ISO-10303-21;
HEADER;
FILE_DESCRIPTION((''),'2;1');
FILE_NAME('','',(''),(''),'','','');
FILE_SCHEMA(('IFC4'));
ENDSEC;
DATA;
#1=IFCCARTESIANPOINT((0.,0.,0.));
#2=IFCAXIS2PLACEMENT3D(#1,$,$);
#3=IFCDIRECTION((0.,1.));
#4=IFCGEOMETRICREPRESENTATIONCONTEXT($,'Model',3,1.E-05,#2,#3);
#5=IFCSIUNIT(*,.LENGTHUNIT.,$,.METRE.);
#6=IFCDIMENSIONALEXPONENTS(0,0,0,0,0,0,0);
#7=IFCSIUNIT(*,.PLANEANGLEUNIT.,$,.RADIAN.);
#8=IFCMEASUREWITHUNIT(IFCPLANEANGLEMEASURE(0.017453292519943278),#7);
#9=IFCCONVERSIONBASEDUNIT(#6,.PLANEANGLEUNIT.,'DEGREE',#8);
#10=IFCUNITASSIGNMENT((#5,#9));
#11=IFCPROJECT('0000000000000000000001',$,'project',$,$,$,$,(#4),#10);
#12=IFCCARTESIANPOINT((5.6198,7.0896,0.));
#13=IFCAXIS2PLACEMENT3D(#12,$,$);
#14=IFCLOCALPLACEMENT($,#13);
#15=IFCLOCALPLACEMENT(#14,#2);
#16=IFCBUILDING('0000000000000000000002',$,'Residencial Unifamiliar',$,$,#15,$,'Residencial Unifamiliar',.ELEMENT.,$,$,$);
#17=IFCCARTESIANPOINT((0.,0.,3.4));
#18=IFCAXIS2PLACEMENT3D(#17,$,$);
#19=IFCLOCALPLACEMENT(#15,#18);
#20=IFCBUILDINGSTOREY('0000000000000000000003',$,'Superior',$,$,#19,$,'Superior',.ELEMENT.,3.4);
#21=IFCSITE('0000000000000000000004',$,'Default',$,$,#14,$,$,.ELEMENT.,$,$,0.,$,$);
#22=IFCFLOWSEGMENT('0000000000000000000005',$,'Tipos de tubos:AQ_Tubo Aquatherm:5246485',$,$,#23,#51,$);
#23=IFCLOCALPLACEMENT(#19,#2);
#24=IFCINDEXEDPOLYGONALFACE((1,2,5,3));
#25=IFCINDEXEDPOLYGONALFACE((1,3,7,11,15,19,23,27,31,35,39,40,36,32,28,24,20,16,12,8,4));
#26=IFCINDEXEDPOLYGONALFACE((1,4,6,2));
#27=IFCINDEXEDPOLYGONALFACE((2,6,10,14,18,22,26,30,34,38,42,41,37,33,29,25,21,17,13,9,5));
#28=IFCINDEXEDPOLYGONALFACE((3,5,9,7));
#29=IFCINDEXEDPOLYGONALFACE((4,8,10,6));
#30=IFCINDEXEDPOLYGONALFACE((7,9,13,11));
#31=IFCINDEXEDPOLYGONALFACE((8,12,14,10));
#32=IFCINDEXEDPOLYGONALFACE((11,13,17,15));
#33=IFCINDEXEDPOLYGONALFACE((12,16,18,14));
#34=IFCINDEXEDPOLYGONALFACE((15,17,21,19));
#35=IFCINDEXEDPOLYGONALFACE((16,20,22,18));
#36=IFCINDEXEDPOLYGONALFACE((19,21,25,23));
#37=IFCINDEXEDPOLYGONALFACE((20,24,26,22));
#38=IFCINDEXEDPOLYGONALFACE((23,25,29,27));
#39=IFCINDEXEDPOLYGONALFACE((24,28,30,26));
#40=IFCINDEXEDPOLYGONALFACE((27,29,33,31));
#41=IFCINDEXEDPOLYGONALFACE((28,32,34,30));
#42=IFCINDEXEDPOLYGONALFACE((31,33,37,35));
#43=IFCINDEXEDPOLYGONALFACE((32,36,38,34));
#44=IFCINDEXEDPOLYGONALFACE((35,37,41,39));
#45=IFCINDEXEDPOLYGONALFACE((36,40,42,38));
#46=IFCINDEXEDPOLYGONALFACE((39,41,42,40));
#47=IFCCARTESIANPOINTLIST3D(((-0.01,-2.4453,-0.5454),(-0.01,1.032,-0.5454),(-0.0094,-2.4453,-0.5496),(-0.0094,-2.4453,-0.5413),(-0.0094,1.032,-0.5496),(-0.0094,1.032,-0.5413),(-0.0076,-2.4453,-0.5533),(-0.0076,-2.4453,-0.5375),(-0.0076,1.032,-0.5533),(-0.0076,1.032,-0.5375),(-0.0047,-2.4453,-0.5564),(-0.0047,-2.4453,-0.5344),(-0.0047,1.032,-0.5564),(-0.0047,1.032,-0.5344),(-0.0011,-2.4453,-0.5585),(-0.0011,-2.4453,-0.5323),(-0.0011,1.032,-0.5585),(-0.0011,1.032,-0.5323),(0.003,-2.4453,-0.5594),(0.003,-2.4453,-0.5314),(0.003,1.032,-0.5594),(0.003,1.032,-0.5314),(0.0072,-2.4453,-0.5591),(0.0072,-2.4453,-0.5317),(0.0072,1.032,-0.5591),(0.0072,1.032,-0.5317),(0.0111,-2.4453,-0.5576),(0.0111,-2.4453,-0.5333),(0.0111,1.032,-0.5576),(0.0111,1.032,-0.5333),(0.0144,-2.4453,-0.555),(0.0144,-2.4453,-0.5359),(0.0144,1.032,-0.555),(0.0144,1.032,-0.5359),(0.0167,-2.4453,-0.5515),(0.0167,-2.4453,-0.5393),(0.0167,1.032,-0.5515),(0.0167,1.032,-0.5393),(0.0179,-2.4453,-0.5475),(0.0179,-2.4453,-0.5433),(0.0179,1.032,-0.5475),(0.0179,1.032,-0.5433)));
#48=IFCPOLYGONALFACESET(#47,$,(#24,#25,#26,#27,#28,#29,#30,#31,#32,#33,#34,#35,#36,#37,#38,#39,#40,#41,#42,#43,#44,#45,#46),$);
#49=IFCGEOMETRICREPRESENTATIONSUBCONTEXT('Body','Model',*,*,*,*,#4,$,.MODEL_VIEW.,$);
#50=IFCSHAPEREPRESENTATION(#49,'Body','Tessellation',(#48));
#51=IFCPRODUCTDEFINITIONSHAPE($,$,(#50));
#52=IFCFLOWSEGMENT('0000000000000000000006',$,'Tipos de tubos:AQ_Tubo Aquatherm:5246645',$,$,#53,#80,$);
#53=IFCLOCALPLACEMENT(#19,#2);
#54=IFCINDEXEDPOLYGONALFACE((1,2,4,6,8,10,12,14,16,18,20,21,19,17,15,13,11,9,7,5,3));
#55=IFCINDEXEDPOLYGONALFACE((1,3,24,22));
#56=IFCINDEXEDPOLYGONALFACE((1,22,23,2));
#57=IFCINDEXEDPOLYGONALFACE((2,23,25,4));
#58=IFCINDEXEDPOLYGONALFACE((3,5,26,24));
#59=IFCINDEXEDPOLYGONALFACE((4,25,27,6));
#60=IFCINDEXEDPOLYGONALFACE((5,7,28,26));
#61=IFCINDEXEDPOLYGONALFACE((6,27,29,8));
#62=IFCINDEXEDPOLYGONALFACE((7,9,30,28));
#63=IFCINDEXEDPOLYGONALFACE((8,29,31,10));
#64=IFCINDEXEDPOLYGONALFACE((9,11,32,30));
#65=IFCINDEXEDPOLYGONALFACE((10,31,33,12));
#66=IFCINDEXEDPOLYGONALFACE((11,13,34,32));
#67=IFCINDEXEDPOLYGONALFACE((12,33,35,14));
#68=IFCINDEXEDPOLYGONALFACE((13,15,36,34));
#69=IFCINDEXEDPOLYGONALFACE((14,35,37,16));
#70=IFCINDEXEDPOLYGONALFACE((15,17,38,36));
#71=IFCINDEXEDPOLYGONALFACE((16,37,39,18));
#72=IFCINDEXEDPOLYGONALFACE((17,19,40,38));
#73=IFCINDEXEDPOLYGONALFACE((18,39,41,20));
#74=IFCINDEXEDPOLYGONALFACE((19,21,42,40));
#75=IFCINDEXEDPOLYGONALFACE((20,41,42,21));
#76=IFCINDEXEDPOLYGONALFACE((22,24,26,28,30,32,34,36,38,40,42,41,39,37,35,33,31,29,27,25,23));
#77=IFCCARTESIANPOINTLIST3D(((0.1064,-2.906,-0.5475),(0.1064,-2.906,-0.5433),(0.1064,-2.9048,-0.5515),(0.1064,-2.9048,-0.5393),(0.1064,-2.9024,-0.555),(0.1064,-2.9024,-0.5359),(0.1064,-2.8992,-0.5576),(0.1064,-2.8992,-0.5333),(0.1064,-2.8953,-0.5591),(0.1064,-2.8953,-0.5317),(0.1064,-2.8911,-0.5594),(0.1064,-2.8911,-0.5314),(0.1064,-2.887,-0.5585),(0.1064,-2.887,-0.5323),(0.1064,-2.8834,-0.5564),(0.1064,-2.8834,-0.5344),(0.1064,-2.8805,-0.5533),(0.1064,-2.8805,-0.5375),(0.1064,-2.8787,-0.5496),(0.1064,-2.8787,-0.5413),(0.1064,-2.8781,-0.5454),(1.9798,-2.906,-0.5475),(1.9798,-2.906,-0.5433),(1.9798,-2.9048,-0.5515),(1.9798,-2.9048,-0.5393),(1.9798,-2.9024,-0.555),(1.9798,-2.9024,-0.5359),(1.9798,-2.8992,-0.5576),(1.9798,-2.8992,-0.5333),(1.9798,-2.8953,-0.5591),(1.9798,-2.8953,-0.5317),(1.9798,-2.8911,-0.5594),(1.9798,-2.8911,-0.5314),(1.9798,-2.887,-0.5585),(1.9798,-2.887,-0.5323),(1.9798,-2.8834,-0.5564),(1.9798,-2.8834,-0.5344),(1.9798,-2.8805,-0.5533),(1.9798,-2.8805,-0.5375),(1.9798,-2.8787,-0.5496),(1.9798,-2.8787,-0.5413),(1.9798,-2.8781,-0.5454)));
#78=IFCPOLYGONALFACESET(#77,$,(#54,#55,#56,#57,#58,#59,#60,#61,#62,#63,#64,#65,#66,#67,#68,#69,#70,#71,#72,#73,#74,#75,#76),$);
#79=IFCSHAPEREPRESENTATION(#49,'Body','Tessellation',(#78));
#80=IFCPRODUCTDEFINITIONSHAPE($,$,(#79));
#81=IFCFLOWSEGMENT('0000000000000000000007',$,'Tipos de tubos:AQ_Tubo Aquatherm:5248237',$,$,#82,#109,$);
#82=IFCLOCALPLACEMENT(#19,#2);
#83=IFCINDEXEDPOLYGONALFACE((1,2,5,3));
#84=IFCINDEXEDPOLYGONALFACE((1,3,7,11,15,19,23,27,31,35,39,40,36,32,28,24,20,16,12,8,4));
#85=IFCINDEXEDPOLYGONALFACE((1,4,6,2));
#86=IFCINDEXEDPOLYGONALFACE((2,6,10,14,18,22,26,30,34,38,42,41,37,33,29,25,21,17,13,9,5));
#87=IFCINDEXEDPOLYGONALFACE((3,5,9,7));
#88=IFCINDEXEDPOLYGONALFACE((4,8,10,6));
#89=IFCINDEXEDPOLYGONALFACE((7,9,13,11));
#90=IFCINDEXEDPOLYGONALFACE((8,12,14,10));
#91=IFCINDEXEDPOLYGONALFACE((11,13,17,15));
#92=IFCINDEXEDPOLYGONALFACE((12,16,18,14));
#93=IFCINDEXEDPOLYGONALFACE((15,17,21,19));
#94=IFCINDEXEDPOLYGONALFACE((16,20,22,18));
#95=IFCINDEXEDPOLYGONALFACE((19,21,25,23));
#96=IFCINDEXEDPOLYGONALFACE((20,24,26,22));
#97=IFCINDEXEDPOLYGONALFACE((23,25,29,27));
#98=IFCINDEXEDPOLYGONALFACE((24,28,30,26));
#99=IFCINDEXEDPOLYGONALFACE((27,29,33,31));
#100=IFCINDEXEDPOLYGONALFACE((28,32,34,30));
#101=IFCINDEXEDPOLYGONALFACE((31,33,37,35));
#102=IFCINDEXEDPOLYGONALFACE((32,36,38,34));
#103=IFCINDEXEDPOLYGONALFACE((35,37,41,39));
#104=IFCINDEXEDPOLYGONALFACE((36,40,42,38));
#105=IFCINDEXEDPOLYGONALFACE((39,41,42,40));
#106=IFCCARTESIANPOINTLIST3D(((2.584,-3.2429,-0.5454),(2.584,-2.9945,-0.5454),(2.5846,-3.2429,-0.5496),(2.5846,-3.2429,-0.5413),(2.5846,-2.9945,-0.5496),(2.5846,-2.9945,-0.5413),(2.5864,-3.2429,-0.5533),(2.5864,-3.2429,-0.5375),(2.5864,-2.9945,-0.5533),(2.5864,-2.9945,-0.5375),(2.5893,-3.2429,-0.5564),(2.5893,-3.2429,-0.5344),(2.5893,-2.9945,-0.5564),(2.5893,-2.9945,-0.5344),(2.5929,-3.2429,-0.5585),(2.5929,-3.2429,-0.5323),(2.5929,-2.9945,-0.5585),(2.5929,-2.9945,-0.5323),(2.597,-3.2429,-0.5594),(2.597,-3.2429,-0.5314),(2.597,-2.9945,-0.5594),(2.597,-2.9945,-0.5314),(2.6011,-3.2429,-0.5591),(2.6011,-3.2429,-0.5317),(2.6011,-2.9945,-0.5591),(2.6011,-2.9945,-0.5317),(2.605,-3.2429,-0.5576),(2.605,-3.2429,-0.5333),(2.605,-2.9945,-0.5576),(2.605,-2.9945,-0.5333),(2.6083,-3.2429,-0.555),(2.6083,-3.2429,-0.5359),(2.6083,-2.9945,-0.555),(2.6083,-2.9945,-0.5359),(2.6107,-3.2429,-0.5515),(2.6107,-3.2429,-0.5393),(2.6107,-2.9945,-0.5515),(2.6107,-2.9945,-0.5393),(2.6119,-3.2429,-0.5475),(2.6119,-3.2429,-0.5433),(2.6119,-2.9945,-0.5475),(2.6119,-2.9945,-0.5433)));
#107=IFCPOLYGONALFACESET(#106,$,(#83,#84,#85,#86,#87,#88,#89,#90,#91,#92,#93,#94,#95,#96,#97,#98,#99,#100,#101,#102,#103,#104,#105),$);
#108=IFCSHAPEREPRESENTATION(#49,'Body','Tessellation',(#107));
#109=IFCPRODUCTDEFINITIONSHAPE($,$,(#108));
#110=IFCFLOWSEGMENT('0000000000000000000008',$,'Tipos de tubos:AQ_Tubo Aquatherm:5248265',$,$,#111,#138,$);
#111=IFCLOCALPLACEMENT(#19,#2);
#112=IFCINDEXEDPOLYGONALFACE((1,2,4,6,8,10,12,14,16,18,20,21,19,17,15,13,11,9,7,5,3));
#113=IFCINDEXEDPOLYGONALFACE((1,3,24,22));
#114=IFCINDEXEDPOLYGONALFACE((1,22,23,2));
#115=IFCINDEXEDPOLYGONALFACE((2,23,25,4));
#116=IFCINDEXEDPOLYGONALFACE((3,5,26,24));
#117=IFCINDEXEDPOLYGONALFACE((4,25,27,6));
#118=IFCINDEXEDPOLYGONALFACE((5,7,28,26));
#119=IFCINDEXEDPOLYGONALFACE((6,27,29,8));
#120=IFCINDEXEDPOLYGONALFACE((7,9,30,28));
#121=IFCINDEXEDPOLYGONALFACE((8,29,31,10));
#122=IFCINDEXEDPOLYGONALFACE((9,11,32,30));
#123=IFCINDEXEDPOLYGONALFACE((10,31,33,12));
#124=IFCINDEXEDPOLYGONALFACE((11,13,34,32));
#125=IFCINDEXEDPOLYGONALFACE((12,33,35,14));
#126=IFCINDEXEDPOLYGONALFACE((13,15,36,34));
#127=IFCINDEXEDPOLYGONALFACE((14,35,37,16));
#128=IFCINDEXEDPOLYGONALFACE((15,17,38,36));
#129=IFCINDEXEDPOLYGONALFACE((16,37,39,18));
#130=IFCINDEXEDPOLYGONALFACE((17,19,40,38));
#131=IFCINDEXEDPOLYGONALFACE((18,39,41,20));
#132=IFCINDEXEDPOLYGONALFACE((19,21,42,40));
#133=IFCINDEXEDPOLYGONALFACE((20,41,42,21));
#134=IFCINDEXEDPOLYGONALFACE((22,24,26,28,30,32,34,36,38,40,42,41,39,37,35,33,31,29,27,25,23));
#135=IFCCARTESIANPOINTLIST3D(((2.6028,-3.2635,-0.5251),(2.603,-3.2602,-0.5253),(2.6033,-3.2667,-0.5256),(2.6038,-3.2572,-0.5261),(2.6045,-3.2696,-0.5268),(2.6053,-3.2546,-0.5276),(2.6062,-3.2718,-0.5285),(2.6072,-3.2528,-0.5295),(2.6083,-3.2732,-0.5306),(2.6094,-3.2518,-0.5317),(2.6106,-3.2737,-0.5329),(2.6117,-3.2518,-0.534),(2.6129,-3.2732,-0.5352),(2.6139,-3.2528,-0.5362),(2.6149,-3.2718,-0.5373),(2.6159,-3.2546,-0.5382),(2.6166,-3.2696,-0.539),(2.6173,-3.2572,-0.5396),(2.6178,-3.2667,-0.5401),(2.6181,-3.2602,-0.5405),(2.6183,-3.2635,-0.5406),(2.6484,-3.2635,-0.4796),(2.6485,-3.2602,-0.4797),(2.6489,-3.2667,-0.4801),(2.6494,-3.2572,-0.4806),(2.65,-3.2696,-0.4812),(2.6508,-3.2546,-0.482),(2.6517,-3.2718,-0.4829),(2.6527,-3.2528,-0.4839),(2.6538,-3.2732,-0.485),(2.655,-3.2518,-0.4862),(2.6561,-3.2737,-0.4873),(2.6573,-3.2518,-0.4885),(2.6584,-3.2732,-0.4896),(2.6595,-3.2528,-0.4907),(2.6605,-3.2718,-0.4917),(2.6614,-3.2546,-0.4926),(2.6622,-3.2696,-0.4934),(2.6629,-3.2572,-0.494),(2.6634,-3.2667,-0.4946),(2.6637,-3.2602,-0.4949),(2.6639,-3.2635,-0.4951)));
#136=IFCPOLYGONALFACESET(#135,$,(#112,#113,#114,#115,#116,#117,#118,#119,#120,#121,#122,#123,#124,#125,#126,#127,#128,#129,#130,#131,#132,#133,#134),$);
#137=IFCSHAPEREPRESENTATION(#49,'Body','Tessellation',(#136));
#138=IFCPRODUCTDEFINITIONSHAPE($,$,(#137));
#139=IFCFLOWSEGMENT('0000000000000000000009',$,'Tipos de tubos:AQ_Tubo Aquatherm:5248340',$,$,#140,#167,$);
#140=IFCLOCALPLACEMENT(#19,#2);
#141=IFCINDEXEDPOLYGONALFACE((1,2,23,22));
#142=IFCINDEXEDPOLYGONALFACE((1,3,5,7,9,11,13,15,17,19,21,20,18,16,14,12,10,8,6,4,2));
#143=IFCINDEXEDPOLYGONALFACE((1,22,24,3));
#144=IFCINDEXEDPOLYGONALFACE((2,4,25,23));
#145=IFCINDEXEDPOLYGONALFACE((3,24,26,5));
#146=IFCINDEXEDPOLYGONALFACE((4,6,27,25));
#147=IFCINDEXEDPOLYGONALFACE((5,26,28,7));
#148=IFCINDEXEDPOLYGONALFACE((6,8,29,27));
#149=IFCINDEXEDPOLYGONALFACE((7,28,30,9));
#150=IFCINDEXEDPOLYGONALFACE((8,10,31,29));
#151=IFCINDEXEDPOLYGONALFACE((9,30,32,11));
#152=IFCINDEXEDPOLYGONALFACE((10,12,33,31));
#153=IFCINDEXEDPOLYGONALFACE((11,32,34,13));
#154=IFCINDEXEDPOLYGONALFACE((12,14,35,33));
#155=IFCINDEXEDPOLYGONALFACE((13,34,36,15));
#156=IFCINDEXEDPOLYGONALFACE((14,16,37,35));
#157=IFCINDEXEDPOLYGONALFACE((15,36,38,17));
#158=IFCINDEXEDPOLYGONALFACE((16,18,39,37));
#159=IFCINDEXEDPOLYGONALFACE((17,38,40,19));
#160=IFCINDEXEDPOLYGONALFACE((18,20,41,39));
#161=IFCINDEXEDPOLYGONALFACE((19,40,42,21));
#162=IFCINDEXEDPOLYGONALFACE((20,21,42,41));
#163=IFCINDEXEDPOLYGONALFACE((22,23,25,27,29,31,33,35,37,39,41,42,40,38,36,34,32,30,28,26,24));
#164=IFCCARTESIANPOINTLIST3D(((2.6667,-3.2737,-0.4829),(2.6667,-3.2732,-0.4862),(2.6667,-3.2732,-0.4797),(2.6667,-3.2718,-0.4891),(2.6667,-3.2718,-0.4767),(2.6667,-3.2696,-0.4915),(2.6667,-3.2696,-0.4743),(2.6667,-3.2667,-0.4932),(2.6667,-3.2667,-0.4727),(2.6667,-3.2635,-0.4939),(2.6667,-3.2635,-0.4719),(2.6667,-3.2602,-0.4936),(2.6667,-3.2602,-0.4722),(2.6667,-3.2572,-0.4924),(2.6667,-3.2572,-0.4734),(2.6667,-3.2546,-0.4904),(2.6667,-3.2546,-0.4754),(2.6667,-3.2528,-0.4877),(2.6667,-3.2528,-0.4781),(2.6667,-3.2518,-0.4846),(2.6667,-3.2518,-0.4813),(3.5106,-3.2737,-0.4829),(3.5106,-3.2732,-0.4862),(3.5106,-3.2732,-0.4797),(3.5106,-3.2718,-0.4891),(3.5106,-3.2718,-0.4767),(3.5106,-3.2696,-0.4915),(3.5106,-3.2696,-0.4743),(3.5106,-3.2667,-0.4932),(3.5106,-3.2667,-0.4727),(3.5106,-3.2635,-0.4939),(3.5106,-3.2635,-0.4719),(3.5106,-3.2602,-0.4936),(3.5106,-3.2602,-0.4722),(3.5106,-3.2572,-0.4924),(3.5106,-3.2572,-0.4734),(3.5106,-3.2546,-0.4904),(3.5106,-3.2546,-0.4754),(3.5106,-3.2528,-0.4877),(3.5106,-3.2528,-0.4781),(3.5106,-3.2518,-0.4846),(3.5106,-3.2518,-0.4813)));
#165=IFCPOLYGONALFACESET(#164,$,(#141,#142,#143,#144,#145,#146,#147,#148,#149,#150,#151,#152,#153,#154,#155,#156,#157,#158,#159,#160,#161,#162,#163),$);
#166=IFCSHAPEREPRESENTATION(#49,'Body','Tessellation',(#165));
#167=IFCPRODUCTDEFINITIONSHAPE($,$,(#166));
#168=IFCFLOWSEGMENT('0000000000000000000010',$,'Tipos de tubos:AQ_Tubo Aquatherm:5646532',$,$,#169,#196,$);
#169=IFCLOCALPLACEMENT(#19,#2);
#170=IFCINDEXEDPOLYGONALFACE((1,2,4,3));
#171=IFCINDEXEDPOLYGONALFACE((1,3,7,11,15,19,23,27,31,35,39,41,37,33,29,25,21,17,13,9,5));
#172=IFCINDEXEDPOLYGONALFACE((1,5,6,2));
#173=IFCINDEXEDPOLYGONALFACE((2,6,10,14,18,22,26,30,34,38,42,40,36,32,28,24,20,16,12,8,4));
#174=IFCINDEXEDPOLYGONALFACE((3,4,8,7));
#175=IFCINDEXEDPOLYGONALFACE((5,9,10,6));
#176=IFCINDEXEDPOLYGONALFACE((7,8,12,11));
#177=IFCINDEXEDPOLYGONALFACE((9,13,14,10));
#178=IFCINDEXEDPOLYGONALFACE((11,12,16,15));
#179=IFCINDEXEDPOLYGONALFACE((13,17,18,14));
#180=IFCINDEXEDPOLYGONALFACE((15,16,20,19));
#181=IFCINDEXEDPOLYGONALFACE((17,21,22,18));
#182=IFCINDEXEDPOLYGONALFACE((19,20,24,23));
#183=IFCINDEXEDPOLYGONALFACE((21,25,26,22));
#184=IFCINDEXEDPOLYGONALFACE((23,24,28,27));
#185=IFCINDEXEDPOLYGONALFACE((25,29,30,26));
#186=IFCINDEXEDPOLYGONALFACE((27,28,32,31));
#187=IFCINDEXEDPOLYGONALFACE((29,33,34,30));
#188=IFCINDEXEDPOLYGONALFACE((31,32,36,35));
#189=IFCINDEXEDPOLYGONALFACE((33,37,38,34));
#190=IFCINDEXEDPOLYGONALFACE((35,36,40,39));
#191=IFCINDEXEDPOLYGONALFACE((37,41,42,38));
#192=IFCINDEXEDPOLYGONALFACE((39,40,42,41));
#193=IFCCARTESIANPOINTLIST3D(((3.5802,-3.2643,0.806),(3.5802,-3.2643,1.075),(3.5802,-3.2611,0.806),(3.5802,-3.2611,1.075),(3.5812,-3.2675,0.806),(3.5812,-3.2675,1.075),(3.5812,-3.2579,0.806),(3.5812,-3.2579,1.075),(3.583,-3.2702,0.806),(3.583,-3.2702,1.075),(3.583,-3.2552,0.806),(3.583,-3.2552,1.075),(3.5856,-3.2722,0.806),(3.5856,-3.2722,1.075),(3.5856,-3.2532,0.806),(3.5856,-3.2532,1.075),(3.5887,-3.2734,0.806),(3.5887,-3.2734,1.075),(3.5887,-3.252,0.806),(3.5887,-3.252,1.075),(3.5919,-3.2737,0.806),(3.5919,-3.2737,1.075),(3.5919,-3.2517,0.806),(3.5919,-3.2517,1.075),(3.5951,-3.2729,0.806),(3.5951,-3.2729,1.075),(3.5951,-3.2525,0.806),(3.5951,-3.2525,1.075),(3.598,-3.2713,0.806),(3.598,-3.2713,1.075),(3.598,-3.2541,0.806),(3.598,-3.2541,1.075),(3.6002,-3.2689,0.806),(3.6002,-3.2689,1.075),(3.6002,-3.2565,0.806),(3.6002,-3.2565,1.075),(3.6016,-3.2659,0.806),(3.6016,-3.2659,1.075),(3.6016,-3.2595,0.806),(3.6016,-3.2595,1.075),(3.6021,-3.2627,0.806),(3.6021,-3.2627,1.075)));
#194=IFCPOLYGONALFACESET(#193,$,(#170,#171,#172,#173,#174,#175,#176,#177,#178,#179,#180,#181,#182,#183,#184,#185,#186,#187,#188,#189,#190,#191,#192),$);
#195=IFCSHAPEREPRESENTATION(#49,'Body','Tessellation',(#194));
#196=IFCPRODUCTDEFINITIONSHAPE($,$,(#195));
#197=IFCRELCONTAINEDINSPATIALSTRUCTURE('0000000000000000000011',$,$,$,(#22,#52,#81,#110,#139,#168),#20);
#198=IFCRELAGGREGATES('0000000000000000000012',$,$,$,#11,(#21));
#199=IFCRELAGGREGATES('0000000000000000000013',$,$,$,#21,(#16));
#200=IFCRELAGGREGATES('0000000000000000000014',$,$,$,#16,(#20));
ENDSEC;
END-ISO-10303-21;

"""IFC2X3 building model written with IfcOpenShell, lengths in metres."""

from ifc_helpers import new_model, entity, si_unit, converted_unit, direction, frame, frame_2d, origin, origin_2d_with_axis, place, context, subcontext, project, spatial, circle, extrude, element, save


model = new_model("IFC2X3")

# Units and contexts
model_context = context("Model", 3, precision=1e-05, world=origin(), true_north=direction((0.0, 1.0)))
body_context = subcontext(model_context, "Body", "Model", "MODEL_VIEW")
ifc_project = project(units=[si_unit("LENGTHUNIT", "METRE"), converted_unit("PLANEANGLEUNIT", "DEGREE", entity("IfcPlaneAngleMeasure", 0.017453292519943278), si_unit("PLANEANGLEUNIT", "RADIAN"), dimensions=[0, 0, 0, 0, 0, 0, 0])], contexts=[model_context])

# Site, building, storey
site_placement = place(None, frame((5.6198, 7.0896, 0.0)))
site = spatial("IfcSite", under=ifc_project, at=site_placement, Name="Default", CompositionType="ELEMENT", RefElevation=0.0)
building_placement = place(site_placement, origin())
building = spatial("IfcBuilding", under=site, at=building_placement, Name="Residencial Unifamiliar", LongName="Residencial Unifamiliar", CompositionType="ELEMENT")
storey_placement = place(building_placement, frame((0.0, 0.0, 3.4)))
storey = spatial("IfcBuildingStorey", under=building, at=storey_placement, Name="Superior", LongName="Superior", CompositionType="ELEMENT", Elevation=3.4)

# Flow segments
flow_segment_1_placement = place(storey_placement, origin())
element("IfcFlowSegment", 1, at=flow_segment_1_placement, inside=storey, Name="Tipos de tubos:AQ_Tubo Aquatherm:5246485", context=body_context, shape_type="SweptSolid", body=[
    extrude(circle(Radius=0.0141, at=frame_2d((0.0, 0.0), x_axis=(1.0, 0.0))), frame((0.0041, -2.4453, -0.5454), z_axis=(0.000001, 1.0, 0.0), x_axis=(-1.0, 0.000001, 0.0)), (0.0, 0.0, 1.0), 3.4773),
])
flow_segment_2_placement = place(storey_placement, origin())
element("IfcFlowSegment", 2, at=flow_segment_2_placement, inside=storey, Name="Tipos de tubos:AQ_Tubo Aquatherm:5246645", context=body_context, shape_type="SweptSolid", body=[
    extrude(circle(Radius=0.0141, at=frame_2d((0.0, 0.0), x_axis=(1.0, 0.0))), frame((0.1064, -2.8921, -0.5454), z_axis=(1.0, 0.0, 0.0), x_axis=(0.0, 1.0, 0.0)), (0.0, 0.0, 1.0), 1.8734),
])
flow_segment_3_placement = place(storey_placement, origin())
element("IfcFlowSegment", 3, at=flow_segment_3_placement, inside=storey, Name="Tipos de tubos:AQ_Tubo Aquatherm:5248237", context=body_context, shape_type="SweptSolid", body=[
    extrude(circle(Radius=0.0141, at=frame_2d((0.0, 0.0), x_axis=(1.0, 0.0))), frame((2.598, -3.2429, -0.5454), z_axis=(0.0, 1.0, 0.0), x_axis=(-1.0, 0.0, 0.0)), (0.0, 0.0, 1.0), 0.2484),
])
flow_segment_4_placement = place(storey_placement, origin())
element("IfcFlowSegment", 4, at=flow_segment_4_placement, inside=storey, Name="Tipos de tubos:AQ_Tubo Aquatherm:5248265", context=body_context, shape_type="SweptSolid", body=[
    extrude(circle(Radius=0.011, at=origin_2d_with_axis()), frame((2.6106, -3.2627, -0.5329), z_axis=(0.707107, 0.0, 0.707107), x_axis=(0.0, -1.0, 0.0)), (0.0, 0.0, 1.0), 0.0644),
])
flow_segment_5_placement = place(storey_placement, origin())
element("IfcFlowSegment", 5, at=flow_segment_5_placement, inside=storey, Name="Tipos de tubos:AQ_Tubo Aquatherm:5248340", context=body_context, shape_type="SweptSolid", body=[
    extrude(circle(Radius=0.011, at=origin_2d_with_axis()), frame((2.6667, -3.2627, -0.4829), z_axis=(1.0, 0.0, 0.0), x_axis=(0.0, -1.0, 0.0)), (0.0, 0.0, 1.0), 0.8439),
])
flow_segment_6_placement = place(storey_placement, origin())
element("IfcFlowSegment", 6, at=flow_segment_6_placement, inside=storey, Name="Tipos de tubos:AQ_Tubo Aquatherm:5646532", context=body_context, shape_type="SweptSolid", body=[
    extrude(circle(Radius=0.011, at=origin_2d_with_axis()), frame((3.5911, -3.2627, 0.806)), (0.0, 0.0, 1.0), 0.269),
])

save(model, "model.ifc")
